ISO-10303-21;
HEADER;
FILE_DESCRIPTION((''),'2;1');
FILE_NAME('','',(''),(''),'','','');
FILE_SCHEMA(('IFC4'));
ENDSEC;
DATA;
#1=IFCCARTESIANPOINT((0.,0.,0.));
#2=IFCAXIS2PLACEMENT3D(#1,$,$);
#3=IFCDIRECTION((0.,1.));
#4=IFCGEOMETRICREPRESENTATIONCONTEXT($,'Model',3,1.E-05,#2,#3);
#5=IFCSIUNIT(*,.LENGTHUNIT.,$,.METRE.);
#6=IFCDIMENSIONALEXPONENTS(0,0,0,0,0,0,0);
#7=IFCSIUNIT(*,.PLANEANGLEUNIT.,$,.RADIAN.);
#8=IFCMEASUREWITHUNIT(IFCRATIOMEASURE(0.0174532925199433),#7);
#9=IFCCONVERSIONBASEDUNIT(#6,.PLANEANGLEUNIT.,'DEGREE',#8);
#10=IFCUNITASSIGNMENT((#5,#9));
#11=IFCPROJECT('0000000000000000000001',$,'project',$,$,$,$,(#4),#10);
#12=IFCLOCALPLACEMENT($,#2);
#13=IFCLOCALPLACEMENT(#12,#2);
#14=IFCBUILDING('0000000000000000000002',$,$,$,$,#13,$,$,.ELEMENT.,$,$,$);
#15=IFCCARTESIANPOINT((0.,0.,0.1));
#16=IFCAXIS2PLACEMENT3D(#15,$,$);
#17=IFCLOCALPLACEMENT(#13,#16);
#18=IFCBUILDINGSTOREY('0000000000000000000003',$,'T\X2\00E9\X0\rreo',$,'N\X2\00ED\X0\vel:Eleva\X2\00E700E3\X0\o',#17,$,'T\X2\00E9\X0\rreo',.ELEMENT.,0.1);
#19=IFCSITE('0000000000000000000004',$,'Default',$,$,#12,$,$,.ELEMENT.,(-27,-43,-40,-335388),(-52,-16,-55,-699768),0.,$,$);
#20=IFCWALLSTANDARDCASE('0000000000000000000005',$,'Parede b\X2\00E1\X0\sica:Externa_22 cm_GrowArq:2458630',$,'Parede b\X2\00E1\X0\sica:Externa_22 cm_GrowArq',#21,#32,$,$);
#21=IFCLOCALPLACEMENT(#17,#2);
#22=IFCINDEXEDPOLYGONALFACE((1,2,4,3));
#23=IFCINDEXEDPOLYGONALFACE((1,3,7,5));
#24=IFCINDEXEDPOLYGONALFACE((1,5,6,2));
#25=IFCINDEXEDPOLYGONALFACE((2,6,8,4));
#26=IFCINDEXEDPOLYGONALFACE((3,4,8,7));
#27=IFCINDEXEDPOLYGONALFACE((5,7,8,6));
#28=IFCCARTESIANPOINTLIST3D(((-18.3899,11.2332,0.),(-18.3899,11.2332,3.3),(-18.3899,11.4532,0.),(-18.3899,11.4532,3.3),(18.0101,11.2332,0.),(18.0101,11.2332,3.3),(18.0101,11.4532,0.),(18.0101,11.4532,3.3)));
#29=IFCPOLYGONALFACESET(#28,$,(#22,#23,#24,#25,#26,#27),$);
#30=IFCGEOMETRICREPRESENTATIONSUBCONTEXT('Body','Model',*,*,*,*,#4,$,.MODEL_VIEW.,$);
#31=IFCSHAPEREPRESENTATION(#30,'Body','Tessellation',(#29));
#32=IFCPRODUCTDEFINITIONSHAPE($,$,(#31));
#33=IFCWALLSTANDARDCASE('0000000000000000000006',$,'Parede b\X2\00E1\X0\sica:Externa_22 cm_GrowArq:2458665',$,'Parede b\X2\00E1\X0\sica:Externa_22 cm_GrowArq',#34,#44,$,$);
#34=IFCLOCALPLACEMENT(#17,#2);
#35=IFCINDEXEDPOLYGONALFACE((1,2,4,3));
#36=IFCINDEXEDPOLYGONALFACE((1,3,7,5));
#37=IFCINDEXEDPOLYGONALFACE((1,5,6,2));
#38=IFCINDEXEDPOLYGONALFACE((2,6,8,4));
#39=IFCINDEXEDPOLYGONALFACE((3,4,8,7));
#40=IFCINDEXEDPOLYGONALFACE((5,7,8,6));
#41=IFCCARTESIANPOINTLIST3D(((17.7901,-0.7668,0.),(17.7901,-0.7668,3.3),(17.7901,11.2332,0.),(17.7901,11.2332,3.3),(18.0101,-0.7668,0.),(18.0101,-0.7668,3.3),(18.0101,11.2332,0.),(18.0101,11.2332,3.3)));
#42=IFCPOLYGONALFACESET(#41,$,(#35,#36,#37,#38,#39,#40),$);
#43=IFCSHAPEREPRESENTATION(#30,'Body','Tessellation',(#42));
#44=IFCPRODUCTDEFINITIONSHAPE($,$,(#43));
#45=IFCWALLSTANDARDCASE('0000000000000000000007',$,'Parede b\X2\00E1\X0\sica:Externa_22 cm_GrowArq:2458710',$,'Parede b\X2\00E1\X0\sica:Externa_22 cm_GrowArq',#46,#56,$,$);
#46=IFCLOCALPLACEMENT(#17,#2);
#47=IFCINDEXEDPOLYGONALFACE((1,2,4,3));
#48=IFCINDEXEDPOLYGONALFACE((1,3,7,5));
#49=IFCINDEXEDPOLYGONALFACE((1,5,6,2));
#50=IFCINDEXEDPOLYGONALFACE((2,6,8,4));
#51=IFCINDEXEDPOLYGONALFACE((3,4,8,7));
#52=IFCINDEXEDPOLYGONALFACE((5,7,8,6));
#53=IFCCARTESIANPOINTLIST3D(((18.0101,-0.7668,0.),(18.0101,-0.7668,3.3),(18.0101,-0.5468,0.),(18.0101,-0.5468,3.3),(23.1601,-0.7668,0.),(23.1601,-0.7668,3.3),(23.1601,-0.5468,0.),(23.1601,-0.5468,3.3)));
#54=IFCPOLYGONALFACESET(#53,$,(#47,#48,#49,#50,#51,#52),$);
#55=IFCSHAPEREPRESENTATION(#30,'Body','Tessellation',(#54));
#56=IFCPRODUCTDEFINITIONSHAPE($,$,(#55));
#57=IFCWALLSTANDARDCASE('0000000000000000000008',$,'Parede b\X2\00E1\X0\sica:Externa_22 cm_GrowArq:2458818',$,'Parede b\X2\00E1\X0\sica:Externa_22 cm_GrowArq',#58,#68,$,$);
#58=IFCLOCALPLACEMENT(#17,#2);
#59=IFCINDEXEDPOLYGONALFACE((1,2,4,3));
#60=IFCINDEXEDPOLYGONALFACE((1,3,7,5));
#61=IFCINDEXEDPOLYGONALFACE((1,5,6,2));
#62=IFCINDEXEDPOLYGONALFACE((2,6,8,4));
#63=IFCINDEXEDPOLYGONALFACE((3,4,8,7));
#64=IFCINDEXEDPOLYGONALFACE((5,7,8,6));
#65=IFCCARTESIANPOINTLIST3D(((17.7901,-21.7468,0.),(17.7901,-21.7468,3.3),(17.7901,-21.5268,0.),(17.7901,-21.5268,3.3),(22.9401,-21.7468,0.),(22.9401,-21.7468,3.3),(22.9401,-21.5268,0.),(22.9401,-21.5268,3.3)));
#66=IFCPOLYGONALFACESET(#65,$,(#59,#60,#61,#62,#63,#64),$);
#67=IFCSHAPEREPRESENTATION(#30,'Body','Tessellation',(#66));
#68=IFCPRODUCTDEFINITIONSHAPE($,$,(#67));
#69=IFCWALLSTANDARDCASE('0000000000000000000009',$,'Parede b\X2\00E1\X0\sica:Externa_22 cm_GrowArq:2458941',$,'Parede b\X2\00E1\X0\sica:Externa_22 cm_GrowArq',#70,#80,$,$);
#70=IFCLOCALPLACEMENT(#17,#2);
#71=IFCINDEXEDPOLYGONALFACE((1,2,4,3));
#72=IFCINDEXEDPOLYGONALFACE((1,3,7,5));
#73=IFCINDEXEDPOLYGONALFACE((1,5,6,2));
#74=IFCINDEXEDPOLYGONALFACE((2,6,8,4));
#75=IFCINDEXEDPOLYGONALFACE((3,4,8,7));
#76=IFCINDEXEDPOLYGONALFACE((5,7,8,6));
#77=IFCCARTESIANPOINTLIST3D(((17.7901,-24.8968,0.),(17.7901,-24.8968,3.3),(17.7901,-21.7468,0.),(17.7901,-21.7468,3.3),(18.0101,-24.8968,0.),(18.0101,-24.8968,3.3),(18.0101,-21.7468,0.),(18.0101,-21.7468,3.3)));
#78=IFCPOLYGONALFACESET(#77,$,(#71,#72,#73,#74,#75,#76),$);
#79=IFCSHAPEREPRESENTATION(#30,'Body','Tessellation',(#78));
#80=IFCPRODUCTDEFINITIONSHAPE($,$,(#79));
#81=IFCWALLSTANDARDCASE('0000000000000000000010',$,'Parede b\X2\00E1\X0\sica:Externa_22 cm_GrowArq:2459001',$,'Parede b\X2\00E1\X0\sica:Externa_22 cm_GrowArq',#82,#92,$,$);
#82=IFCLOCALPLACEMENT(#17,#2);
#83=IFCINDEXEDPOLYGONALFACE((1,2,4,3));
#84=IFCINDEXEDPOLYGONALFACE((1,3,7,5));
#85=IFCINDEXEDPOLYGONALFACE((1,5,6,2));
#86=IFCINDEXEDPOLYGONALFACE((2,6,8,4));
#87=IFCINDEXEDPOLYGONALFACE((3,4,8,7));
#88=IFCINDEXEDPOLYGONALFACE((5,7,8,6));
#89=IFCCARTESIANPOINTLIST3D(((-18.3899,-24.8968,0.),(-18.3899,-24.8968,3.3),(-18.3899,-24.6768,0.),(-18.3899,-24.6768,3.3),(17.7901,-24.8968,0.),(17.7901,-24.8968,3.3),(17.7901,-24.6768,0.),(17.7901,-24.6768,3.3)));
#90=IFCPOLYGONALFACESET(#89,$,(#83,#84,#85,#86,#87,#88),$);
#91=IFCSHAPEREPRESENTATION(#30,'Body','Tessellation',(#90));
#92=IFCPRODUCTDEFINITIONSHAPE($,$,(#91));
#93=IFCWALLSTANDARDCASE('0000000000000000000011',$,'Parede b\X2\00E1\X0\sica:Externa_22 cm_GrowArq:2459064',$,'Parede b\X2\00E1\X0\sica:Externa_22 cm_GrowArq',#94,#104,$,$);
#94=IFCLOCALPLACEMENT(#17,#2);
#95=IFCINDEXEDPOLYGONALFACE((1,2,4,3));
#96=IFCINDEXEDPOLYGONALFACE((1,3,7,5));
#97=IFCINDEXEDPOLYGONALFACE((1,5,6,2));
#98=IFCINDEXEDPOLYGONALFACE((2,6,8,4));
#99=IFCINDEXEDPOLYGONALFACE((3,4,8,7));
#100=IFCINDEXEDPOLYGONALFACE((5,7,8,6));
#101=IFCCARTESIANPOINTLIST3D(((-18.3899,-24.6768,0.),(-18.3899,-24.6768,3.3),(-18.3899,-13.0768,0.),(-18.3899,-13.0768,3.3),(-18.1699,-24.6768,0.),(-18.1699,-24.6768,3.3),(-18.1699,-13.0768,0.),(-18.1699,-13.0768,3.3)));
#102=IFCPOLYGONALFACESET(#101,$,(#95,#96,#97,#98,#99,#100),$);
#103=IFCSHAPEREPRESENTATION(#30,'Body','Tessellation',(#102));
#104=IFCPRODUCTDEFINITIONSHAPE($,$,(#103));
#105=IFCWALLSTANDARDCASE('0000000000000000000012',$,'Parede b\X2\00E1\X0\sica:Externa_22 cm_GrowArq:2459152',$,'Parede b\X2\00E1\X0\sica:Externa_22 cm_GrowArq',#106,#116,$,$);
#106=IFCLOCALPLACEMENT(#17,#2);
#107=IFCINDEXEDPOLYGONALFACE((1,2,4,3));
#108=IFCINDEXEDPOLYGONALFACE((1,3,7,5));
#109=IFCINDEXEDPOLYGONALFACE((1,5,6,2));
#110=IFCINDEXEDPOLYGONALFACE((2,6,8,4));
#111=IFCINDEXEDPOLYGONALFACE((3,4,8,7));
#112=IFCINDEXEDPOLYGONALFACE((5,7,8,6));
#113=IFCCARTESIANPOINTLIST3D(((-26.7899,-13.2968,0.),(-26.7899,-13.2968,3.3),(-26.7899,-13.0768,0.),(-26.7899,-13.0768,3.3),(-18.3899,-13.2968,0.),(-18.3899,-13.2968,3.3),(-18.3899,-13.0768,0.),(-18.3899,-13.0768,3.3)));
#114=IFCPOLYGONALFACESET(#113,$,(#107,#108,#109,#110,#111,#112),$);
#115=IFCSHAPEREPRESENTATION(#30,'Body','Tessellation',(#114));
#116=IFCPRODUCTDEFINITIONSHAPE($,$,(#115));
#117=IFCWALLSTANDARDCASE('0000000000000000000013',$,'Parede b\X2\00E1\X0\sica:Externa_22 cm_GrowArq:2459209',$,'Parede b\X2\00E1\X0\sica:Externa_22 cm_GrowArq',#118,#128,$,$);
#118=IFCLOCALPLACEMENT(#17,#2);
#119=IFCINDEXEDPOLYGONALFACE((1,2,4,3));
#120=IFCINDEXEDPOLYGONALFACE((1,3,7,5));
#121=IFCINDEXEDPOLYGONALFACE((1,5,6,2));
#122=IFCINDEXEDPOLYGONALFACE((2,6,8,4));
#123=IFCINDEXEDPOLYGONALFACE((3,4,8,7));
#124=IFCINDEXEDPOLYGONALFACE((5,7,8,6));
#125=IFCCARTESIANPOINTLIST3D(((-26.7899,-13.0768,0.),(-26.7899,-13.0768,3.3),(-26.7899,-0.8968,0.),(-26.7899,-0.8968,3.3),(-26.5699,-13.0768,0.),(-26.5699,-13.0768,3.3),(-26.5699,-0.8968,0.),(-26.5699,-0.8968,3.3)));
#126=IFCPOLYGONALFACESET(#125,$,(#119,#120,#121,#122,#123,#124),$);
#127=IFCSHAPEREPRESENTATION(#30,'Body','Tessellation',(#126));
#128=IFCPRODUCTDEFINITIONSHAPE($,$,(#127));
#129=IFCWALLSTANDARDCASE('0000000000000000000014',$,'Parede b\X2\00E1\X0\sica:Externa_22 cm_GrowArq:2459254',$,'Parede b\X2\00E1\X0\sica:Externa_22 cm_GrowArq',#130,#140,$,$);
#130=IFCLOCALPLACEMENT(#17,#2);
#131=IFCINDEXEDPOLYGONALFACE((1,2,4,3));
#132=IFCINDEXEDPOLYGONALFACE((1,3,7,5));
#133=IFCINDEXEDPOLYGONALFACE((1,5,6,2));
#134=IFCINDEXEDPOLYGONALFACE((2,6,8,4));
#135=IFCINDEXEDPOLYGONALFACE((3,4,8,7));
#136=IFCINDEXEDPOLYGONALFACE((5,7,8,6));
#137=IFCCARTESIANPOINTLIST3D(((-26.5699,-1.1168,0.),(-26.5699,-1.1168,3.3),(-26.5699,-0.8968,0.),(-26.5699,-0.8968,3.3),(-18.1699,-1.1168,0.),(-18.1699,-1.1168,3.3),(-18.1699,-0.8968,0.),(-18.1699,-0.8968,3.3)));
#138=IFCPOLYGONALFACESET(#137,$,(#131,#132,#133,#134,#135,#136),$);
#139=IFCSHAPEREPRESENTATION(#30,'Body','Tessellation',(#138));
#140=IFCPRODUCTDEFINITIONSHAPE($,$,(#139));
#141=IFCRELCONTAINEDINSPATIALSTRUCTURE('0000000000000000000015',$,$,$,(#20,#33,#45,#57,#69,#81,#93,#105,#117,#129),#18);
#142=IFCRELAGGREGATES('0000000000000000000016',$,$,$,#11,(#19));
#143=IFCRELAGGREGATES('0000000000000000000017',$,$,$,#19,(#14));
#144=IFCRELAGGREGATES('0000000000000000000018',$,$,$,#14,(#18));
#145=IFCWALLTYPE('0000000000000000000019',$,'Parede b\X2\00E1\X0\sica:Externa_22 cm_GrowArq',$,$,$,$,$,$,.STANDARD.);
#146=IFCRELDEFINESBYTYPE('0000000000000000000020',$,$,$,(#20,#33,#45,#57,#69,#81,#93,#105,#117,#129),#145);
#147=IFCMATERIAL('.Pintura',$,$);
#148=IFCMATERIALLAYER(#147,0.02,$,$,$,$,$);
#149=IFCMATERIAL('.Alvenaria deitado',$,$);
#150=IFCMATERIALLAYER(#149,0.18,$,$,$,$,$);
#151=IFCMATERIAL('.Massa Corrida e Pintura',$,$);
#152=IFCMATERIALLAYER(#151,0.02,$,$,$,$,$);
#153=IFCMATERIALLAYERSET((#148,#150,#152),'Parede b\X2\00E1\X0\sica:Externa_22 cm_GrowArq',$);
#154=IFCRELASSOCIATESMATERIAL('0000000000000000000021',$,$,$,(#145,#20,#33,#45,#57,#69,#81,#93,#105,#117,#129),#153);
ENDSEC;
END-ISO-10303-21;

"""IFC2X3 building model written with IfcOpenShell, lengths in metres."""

from ifc_helpers import new_model, entity, si_unit, converted_unit, direction, frame, frame_2d, origin, place, context, subcontext, project, spatial, rectangle, extrude, material, layer, layer_set, layer_usage, type_object, element, save


model = new_model("IFC2X3")

# Units and contexts
model_context = context("Model", 3, precision=1e-05, world=origin(), true_north=direction((0.0, 1.0)))
body_context = subcontext(model_context, "Body", "Model", "MODEL_VIEW")
ifc_project = project(units=[si_unit("LENGTHUNIT", "METRE"), converted_unit("PLANEANGLEUNIT", "DEGREE", entity("IfcRatioMeasure", 0.0174532925199433), si_unit("PLANEANGLEUNIT", "RADIAN"), dimensions=[0, 0, 0, 0, 0, 0, 0])], contexts=[model_context])

# Site, building, storey
site_placement = place(None, origin())
site = spatial("IfcSite", under=ifc_project, at=site_placement, Name="Default", CompositionType="ELEMENT", RefLatitude=(-27, -43, -40, -335388), RefLongitude=(-52, -16, -55, -699768), RefElevation=0.0)
building_placement = place(site_placement, origin())
building = spatial("IfcBuilding", under=site, at=building_placement, CompositionType="ELEMENT")
storey_placement = place(building_placement, frame((0.0, 0.0, 0.1)))
storey = spatial("IfcBuildingStorey", under=building, at=storey_placement, Name="Térreo", ObjectType="Nível:Elevação", LongName="Térreo", CompositionType="ELEMENT", Elevation=0.1)

# Walls
ifc_material_1 = material(Name=".Pintura")
ifc_layer_1 = layer(ifc_material_1, 0.02)
ifc_material_2 = material(Name=".Alvenaria deitado")
ifc_layer_2 = layer(ifc_material_2, 0.18)
ifc_material_3 = material(Name=".Massa Corrida e Pintura")
ifc_layer_3 = layer(ifc_material_3, 0.02)
ifc_layer_set_1 = layer_set([ifc_layer_1, ifc_layer_2, ifc_layer_3], Name="Parede básica:Externa_22 cm_GrowArq")
ifc_layer_usage_1 = layer_usage(ifc_layer_set_1, "AXIS2", "NEGATIVE", 0.11)
wall_type = type_object("IfcWallType", Name="Parede básica:Externa_22 cm_GrowArq", PredefinedType="STANDARD", material=ifc_layer_set_1)
wall_1_placement = place(storey_placement, frame((-18.3899, 11.3432, 0.0)))
element("IfcWallStandardCase", 1, at=wall_1_placement, inside=storey, type_object=wall_type, material=ifc_layer_usage_1, Name="Parede básica:Externa_22 cm_GrowArq:2458630", ObjectType="Parede básica:Externa_22 cm_GrowArq", context=body_context, shape_type="SweptSolid", body=[
    extrude(rectangle(XDim=36.4, YDim=0.22, at=frame_2d((18.2, 0.0), x_axis=(-1.0, 0.0))), origin(), (0.0, 0.0, 1.0), 3.3),
])
ifc_layer_usage_2 = layer_usage(ifc_layer_set_1, "AXIS2", "NEGATIVE", 0.11)
wall_2_placement = place(storey_placement, frame((17.9001, 11.2332, 0.0), z_axis=(0.0, 0.0, 1.0), x_axis=(0.0, -1.0, 0.0)))
element("IfcWallStandardCase", 2, at=wall_2_placement, inside=storey, type_object=wall_type, material=ifc_layer_usage_2, Name="Parede básica:Externa_22 cm_GrowArq:2458665", ObjectType="Parede básica:Externa_22 cm_GrowArq", context=body_context, shape_type="SweptSolid", body=[
    extrude(rectangle(XDim=12.0, YDim=0.22, at=frame_2d((6.0, 0.0), x_axis=(-1.0, 0.0))), origin(), (0.0, 0.0, 1.0), 3.3),
])
ifc_layer_usage_3 = layer_usage(ifc_layer_set_1, "AXIS2", "NEGATIVE", 0.11)
wall_3_placement = place(storey_placement, frame((18.0101, -0.6568, 0.0)))
element("IfcWallStandardCase", 3, at=wall_3_placement, inside=storey, type_object=wall_type, material=ifc_layer_usage_3, Name="Parede básica:Externa_22 cm_GrowArq:2458710", ObjectType="Parede básica:Externa_22 cm_GrowArq", context=body_context, shape_type="SweptSolid", body=[
    extrude(rectangle(XDim=5.15, YDim=0.22, at=frame_2d((2.575, 0.0), x_axis=(-1.0, 0.0))), origin(), (0.0, 0.0, 1.0), 3.3),
])

# Walls
ifc_layer_usage_4 = layer_usage(ifc_layer_set_1, "AXIS2", "NEGATIVE", 0.11)
wall_4_placement = place(storey_placement, frame((22.9401, -21.6368, 0.0), z_axis=(0.0, 0.0, 1.0), x_axis=(-1.0, 0.0, 0.0)))
element("IfcWallStandardCase", 4, at=wall_4_placement, inside=storey, type_object=wall_type, material=ifc_layer_usage_4, Name="Parede básica:Externa_22 cm_GrowArq:2458818", ObjectType="Parede básica:Externa_22 cm_GrowArq", context=body_context, shape_type="SweptSolid", body=[
    extrude(rectangle(XDim=5.15, YDim=0.22, at=frame_2d((2.575, 0.0), x_axis=(-1.0, 0.0))), origin(), (0.0, 0.0, 1.0), 3.3),
])
ifc_layer_usage_5 = layer_usage(ifc_layer_set_1, "AXIS2", "NEGATIVE", 0.11)
wall_5_placement = place(storey_placement, frame((17.9001, -21.7468, 0.0), z_axis=(0.0, 0.0, 1.0), x_axis=(0.0, -1.0, 0.0)))
element("IfcWallStandardCase", 5, at=wall_5_placement, inside=storey, type_object=wall_type, material=ifc_layer_usage_5, Name="Parede básica:Externa_22 cm_GrowArq:2458941", ObjectType="Parede básica:Externa_22 cm_GrowArq", context=body_context, shape_type="SweptSolid", body=[
    extrude(rectangle(XDim=3.15, YDim=0.22, at=frame_2d((1.575, 0.0), x_axis=(-1.0, 0.0))), origin(), (0.0, 0.0, 1.0), 3.3),
])
ifc_layer_usage_6 = layer_usage(ifc_layer_set_1, "AXIS2", "NEGATIVE", 0.11)
wall_6_placement = place(storey_placement, frame((17.7901, -24.7868, 0.0), z_axis=(0.0, 0.0, 1.0), x_axis=(-1.0, 0.0, 0.0)))
element("IfcWallStandardCase", 6, at=wall_6_placement, inside=storey, type_object=wall_type, material=ifc_layer_usage_6, Name="Parede básica:Externa_22 cm_GrowArq:2459001", ObjectType="Parede básica:Externa_22 cm_GrowArq", context=body_context, shape_type="SweptSolid", body=[
    extrude(rectangle(XDim=36.18, YDim=0.22, at=frame_2d((18.09, 0.0), x_axis=(-1.0, 0.0))), origin(), (0.0, 0.0, 1.0), 3.3),
])
ifc_layer_usage_7 = layer_usage(ifc_layer_set_1, "AXIS2", "NEGATIVE", 0.11)
wall_7_placement = place(storey_placement, frame((-18.2799, -24.6768, 0.0), z_axis=(0.0, 0.0, 1.0), x_axis=(0.0, 1.0, 0.0)))
element("IfcWallStandardCase", 7, at=wall_7_placement, inside=storey, type_object=wall_type, material=ifc_layer_usage_7, Name="Parede básica:Externa_22 cm_GrowArq:2459064", ObjectType="Parede básica:Externa_22 cm_GrowArq", context=body_context, shape_type="SweptSolid", body=[
    extrude(rectangle(XDim=11.6, YDim=0.22, at=frame_2d((5.8, 0.0), x_axis=(-1.0, 0.0))), origin(), (0.0, 0.0, 1.0), 3.3),
])
ifc_layer_usage_8 = layer_usage(ifc_layer_set_1, "AXIS2", "NEGATIVE", 0.11)
wall_8_placement = place(storey_placement, frame((-18.3899, -13.1868, 0.0), z_axis=(0.0, 0.0, 1.0), x_axis=(-1.0, 0.0, 0.0)))
element("IfcWallStandardCase", 8, at=wall_8_placement, inside=storey, type_object=wall_type, material=ifc_layer_usage_8, Name="Parede básica:Externa_22 cm_GrowArq:2459152", ObjectType="Parede básica:Externa_22 cm_GrowArq", context=body_context, shape_type="SweptSolid", body=[
    extrude(rectangle(XDim=8.4, YDim=0.22, at=frame_2d((4.2, 0.0), x_axis=(-1.0, 0.0))), origin(), (0.0, 0.0, 1.0), 3.3),
])
ifc_layer_usage_9 = layer_usage(ifc_layer_set_1, "AXIS2", "NEGATIVE", 0.11)
wall_9_placement = place(storey_placement, frame((-26.6799, -13.0768, 0.0), z_axis=(0.0, 0.0, 1.0), x_axis=(0.0, 1.0, 0.0)))
element("IfcWallStandardCase", 9, at=wall_9_placement, inside=storey, type_object=wall_type, material=ifc_layer_usage_9, Name="Parede básica:Externa_22 cm_GrowArq:2459209", ObjectType="Parede básica:Externa_22 cm_GrowArq", context=body_context, shape_type="SweptSolid", body=[
    extrude(rectangle(XDim=12.18, YDim=0.22, at=frame_2d((6.09, 0.0), x_axis=(-1.0, 0.0))), origin(), (0.0, 0.0, 1.0), 3.3),
])
ifc_layer_usage_10 = layer_usage(ifc_layer_set_1, "AXIS2", "NEGATIVE", 0.11)
wall_10_placement = place(storey_placement, frame((-26.5699, -1.0068, 0.0)))
element("IfcWallStandardCase", 10, at=wall_10_placement, inside=storey, type_object=wall_type, material=ifc_layer_usage_10, Name="Parede básica:Externa_22 cm_GrowArq:2459254", ObjectType="Parede básica:Externa_22 cm_GrowArq", context=body_context, shape_type="SweptSolid", body=[
    extrude(rectangle(XDim=8.4, YDim=0.22, at=frame_2d((4.2, 0.0), x_axis=(-1.0, 0.0))), origin(), (0.0, 0.0, 1.0), 3.3),
])

save(model, "model.ifc")
